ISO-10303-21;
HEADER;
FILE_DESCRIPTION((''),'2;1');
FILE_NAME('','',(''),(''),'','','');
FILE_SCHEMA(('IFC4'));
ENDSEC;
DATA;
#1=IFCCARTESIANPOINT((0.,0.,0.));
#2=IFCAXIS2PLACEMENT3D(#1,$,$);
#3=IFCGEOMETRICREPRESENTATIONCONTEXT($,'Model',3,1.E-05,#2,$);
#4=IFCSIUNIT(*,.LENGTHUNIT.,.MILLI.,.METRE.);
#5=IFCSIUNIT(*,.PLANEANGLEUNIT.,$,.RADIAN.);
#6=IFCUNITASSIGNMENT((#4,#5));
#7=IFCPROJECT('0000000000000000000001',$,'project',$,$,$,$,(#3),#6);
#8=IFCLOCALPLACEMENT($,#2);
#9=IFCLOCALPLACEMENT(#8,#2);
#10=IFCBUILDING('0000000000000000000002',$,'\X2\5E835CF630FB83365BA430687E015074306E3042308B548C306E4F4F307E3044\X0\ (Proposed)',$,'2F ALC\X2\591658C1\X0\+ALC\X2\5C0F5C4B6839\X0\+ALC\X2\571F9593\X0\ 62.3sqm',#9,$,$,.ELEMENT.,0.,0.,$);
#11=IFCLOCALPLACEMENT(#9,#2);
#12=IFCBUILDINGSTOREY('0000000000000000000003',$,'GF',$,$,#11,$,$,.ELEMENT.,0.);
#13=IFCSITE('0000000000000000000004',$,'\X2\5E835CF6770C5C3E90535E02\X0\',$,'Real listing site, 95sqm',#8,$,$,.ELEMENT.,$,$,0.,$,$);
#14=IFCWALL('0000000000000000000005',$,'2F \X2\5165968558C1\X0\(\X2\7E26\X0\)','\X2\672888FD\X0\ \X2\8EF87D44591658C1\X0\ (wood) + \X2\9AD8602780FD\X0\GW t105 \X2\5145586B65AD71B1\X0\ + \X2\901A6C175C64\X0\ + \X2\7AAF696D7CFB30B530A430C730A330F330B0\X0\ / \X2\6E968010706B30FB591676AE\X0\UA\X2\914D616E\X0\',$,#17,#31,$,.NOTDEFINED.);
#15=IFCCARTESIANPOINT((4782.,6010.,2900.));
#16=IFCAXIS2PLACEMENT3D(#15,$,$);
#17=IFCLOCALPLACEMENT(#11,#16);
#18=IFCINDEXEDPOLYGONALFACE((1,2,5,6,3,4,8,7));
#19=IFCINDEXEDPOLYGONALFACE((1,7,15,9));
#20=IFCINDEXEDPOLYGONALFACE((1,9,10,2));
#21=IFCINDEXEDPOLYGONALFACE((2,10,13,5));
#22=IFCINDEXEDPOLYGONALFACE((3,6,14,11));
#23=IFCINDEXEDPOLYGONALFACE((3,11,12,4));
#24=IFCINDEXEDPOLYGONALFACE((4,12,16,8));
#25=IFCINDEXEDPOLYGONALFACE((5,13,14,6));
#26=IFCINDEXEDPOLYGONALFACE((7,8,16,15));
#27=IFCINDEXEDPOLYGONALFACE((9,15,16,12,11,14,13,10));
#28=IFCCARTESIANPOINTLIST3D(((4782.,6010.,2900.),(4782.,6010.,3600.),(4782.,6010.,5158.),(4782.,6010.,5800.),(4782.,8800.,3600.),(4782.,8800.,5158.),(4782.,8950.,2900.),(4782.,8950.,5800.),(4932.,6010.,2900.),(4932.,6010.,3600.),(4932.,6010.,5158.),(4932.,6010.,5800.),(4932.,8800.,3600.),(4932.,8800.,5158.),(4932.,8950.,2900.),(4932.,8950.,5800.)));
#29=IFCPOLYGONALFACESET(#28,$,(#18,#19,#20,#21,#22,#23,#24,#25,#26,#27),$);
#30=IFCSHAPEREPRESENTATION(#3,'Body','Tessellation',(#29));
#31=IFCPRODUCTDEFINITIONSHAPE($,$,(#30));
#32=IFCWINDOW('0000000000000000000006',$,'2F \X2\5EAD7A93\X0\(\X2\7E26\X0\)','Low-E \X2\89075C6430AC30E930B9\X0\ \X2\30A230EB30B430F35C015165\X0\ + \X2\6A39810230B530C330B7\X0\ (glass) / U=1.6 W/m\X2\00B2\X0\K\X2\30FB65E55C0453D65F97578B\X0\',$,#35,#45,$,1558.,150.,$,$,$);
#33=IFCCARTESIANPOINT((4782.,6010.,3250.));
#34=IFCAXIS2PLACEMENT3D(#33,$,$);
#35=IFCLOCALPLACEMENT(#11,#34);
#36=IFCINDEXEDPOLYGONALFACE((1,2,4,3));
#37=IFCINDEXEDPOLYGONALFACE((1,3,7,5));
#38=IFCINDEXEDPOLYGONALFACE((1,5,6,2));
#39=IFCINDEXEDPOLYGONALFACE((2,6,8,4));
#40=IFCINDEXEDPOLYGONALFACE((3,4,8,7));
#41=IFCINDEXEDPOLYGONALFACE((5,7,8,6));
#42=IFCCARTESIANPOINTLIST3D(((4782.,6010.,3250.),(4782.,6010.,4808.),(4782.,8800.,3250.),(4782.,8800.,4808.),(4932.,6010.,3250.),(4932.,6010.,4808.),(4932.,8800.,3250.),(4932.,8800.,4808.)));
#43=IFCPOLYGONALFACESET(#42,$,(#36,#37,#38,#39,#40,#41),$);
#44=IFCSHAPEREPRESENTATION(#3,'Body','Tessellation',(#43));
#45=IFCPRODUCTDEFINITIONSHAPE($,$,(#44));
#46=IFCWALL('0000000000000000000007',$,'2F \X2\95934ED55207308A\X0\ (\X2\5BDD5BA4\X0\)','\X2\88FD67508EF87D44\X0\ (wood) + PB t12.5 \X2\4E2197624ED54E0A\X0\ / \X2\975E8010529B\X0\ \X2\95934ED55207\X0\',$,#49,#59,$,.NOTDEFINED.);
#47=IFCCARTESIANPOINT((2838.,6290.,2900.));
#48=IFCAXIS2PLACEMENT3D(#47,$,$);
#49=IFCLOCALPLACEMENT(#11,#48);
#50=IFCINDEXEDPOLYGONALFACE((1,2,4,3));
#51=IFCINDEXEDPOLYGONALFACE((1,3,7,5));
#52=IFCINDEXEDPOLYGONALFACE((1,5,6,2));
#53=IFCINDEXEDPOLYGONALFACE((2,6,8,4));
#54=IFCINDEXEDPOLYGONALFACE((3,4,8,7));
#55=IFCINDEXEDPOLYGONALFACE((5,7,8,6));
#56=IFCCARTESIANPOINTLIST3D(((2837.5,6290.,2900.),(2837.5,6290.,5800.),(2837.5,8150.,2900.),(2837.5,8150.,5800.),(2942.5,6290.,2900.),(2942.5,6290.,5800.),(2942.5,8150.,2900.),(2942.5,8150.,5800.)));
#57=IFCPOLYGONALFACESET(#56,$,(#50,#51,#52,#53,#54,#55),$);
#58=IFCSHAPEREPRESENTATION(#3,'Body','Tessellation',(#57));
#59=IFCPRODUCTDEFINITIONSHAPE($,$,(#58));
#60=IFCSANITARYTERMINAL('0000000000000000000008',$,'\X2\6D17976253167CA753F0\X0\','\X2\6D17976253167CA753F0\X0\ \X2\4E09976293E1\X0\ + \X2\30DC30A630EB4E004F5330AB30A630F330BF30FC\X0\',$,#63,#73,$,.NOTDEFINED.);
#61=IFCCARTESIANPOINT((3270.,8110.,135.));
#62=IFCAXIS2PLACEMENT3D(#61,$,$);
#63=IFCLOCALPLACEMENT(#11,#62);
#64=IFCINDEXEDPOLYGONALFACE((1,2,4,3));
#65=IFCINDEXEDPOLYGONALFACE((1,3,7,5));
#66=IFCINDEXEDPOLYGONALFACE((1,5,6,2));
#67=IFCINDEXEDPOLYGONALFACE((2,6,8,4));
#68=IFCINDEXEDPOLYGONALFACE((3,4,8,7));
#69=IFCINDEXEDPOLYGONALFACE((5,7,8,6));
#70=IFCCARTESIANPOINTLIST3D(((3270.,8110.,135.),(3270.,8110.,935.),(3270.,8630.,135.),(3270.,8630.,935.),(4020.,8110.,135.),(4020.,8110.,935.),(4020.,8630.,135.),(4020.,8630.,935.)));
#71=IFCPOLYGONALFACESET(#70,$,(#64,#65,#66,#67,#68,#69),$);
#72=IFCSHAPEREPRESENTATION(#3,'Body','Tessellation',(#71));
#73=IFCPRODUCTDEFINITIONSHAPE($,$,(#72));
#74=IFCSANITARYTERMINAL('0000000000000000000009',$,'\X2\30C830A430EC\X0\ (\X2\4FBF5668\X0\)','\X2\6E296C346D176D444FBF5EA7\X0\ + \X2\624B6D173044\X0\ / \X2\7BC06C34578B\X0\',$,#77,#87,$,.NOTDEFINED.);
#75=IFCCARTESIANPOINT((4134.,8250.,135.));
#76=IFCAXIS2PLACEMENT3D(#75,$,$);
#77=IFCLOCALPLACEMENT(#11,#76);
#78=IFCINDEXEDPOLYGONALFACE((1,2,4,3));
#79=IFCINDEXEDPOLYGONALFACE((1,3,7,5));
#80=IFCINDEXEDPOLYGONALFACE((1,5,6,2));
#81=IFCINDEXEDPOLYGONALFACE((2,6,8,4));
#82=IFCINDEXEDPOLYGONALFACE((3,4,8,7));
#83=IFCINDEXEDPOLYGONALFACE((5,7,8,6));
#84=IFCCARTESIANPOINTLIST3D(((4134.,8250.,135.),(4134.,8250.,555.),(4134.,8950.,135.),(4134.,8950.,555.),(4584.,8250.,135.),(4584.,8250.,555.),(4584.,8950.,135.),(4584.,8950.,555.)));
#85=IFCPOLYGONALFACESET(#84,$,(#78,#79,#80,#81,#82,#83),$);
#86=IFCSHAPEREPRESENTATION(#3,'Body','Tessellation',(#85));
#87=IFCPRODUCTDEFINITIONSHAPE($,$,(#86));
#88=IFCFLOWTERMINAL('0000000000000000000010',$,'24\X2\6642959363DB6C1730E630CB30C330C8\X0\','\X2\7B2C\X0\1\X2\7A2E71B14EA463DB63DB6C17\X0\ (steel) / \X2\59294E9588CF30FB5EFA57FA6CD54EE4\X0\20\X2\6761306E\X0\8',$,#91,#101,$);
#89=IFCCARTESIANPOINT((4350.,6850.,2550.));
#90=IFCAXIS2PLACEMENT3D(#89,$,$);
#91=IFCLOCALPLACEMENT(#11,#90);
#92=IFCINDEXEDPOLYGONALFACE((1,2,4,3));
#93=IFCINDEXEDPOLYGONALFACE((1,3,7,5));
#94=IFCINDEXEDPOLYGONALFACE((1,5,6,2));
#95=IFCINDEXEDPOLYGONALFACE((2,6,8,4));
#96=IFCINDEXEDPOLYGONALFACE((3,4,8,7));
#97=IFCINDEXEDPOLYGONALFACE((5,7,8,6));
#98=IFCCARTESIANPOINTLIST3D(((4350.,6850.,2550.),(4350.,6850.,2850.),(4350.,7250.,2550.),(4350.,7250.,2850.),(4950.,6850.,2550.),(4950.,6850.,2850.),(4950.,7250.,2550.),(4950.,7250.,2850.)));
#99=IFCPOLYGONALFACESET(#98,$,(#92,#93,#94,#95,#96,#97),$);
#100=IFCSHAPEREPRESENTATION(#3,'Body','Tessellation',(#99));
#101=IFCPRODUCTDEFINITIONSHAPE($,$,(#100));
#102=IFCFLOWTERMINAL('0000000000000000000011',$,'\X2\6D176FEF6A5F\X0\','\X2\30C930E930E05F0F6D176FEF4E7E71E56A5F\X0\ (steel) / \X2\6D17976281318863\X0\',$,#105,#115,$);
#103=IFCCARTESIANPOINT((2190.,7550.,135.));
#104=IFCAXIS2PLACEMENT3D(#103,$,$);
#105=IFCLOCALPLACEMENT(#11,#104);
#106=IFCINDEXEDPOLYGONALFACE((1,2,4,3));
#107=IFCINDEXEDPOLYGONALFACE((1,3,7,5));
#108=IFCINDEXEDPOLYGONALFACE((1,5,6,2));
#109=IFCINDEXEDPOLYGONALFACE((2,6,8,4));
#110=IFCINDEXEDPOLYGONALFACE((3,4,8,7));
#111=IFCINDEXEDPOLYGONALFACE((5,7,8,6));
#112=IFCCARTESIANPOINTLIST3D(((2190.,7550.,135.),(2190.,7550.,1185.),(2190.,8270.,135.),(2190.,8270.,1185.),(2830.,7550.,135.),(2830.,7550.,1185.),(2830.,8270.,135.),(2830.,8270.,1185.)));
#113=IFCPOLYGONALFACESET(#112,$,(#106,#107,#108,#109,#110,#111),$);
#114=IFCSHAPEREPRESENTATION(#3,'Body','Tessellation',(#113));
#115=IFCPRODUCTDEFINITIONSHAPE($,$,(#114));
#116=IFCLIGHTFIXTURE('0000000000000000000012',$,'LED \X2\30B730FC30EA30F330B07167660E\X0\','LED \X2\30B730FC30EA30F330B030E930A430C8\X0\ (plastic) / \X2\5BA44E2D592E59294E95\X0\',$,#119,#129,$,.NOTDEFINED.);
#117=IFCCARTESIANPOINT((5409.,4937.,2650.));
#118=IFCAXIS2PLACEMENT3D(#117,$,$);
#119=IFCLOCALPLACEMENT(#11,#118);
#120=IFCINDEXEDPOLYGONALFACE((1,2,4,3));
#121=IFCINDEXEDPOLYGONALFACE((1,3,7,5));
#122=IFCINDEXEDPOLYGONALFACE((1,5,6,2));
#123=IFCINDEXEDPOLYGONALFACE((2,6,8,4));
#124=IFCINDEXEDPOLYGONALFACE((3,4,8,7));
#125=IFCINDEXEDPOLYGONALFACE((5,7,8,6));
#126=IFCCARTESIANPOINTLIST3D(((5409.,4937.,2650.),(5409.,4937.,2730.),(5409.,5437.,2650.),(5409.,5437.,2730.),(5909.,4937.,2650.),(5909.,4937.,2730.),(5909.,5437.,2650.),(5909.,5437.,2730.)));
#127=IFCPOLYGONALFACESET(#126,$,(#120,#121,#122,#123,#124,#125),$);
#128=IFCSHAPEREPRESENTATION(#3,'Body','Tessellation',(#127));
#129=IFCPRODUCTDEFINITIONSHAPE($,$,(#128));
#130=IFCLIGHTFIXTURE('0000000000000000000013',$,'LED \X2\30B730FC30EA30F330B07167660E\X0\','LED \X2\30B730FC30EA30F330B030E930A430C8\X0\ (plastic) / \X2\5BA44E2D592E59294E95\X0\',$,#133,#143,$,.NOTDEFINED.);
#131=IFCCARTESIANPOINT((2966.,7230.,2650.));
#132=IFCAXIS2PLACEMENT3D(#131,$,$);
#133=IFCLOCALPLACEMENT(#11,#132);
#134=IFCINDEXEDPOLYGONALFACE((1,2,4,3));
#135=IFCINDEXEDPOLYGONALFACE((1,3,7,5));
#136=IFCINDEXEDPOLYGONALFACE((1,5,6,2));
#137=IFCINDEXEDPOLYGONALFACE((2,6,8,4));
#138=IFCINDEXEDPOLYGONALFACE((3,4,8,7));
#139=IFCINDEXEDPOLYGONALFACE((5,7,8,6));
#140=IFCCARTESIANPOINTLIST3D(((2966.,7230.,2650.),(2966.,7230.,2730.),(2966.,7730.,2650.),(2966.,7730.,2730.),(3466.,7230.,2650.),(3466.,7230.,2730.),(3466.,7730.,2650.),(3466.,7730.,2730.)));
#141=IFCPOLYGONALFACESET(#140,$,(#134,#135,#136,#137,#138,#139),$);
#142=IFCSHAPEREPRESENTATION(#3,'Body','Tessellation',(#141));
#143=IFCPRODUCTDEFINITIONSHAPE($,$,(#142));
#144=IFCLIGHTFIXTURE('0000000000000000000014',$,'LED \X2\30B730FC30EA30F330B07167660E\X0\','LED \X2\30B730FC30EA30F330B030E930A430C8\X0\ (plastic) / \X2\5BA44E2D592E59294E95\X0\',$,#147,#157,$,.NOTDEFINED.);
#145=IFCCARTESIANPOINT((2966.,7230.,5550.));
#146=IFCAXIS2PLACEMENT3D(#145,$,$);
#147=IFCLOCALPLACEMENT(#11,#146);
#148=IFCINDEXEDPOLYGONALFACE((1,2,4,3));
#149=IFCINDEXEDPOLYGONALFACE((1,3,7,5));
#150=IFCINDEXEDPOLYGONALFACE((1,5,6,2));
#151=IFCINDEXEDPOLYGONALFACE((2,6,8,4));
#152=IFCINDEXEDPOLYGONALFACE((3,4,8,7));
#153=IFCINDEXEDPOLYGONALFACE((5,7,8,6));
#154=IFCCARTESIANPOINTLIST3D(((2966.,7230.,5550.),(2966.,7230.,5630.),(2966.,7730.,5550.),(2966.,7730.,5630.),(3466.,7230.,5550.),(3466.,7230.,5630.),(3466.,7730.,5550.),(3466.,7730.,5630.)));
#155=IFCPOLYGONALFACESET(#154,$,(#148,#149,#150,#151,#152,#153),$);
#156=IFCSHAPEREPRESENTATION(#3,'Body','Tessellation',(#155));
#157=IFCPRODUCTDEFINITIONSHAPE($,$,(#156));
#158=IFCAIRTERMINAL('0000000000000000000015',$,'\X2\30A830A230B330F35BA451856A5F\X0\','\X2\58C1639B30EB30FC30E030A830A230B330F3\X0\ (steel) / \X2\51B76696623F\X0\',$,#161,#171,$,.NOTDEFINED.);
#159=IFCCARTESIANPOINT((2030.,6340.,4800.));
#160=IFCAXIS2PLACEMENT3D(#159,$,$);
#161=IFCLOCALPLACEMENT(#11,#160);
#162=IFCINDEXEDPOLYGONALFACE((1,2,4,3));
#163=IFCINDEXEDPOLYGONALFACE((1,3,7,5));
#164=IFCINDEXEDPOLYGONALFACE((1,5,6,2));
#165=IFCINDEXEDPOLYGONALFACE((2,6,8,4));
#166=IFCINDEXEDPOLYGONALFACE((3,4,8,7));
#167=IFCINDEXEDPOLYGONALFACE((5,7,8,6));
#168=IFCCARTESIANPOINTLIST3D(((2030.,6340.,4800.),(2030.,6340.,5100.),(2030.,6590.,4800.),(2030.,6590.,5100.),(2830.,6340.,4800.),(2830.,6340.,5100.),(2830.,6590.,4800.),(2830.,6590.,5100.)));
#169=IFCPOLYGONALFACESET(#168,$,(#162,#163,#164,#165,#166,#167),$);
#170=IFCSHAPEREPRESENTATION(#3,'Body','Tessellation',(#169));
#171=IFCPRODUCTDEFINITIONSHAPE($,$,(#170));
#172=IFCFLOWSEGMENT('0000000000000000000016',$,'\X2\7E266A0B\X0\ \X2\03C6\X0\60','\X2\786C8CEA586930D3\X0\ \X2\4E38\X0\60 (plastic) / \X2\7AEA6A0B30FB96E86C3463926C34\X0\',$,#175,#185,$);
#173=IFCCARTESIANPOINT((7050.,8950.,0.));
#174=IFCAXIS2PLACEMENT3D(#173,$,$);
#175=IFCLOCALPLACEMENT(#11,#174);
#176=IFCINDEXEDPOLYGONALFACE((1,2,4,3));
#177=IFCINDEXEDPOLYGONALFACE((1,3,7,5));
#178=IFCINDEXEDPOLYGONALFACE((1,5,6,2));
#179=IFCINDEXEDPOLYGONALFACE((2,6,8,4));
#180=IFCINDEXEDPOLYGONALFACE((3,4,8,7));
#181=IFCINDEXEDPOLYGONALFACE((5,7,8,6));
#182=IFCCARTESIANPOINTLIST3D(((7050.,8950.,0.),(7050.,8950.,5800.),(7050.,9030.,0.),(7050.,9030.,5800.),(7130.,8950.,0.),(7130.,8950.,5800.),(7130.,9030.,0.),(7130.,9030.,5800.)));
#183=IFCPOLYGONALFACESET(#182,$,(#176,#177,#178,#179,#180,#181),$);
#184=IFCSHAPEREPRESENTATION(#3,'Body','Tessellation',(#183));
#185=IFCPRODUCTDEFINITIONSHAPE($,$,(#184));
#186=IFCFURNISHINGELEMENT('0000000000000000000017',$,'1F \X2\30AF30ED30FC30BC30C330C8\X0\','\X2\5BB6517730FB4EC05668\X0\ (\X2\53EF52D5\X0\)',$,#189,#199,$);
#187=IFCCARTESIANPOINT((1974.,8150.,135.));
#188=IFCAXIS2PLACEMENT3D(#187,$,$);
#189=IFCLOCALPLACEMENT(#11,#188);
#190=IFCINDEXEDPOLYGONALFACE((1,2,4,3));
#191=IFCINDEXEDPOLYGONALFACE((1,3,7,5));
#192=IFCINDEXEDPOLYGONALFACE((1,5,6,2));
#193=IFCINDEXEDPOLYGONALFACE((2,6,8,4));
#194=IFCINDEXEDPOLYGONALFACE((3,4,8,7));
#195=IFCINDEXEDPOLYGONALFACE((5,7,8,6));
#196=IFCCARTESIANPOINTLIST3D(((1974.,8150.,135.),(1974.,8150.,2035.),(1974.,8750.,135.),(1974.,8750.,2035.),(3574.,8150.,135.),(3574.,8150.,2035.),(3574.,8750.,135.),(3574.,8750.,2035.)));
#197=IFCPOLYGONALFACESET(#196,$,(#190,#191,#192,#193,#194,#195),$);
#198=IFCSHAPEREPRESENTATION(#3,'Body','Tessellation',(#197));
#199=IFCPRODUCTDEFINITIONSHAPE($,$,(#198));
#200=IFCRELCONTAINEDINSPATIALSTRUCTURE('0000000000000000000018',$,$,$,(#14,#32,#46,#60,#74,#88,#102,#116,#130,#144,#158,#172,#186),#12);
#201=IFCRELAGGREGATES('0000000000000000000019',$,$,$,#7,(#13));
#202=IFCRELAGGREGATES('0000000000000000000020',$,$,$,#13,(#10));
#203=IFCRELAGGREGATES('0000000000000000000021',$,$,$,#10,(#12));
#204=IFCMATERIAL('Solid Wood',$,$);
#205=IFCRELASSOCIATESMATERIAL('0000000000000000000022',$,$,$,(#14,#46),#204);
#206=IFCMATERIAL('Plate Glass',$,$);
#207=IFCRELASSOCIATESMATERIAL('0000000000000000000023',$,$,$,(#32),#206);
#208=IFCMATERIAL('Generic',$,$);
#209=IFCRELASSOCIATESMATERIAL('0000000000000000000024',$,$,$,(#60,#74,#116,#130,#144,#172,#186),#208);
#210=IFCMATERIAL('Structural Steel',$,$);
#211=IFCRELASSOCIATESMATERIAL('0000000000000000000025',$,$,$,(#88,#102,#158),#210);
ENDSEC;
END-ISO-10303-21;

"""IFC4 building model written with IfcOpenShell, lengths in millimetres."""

from ifc_helpers import new_model, si_unit, frame, frame_2d, origin, place, context, project, spatial, rectangle, extrude, material, element, fill, save


model = new_model("IFC4")

# Units and contexts
model_context = context("Model", 3, precision=1e-05, world=origin())
ifc_project = project(units=[si_unit("LENGTHUNIT", "METRE", prefix="MILLI"), si_unit("PLANEANGLEUNIT", "RADIAN")], contexts=[model_context])

# Site, building, storey
site_placement = place(None, origin())
site = spatial("IfcSite", under=ifc_project, at=site_placement, Name="広島県尾道市", ObjectType="Real listing site, 95sqm", CompositionType="ELEMENT", RefElevation=0.0)
building_placement = place(site_placement, origin())
building = spatial("IfcBuilding", under=site, at=building_placement, Name="広島・茶室と縁側のある和の住まい (Proposed)", ObjectType="2F ALC外壁+ALC小屋根+ALC土間 62.3sqm", CompositionType="ELEMENT", ElevationOfRefHeight=0.0, ElevationOfTerrain=0.0)
storey_placement = place(building_placement, origin())
storey = spatial("IfcBuildingStorey", under=building, at=storey_placement, Name="GF", CompositionType="ELEMENT", Elevation=0.0)

# Shared definitions
ifc_material_1 = material(Name="Solid Wood")

# Shared definitions
ifc_material_2 = material(Name="Plate Glass")

# Wall, opening, window
wall_1_placement = place(storey_placement, frame((4782.0, 6010.0, 2900.0)))
wall_1 = element("IfcWall", 1, at=wall_1_placement, inside=storey, material=ifc_material_1, Name="2F 入隅壁(縦)", Description="木製 軸組外壁 (wood) + 高性能GW t105 充填断熱 + 通気層 + 窯業系サイディング / 準耐火・外皮UA配慮", PredefinedType="NOTDEFINED", context=model_context, shape_type="SweptSolid", body=[
    extrude(rectangle(XDim=150.0, YDim=2940.0, at=frame_2d((75.0, 1470.0))), frame((4782.0, 6010.0, 2900.0)), (0.0, 0.0, 1.0), 2900.0),
])
opening_1_placement = place(storey_placement, frame((4782.0, 6010.0, 3250.0)))
opening_1 = element("IfcOpeningElement", 2, at=opening_1_placement, cuts=wall_1, PredefinedType="NOTDEFINED", context=model_context, shape_type="SweptSolid", body=[
    extrude(rectangle(XDim=150.0, YDim=2790.0, at=frame_2d((75.0, 1395.0))), frame((4782.0, 6010.0, 3250.0)), (0.0, 0.0, 1.0), 1558.0),
])
window_1_placement = place(storey_placement, frame((4782.0, 6010.0, 3250.0)))
window_1 = element("IfcWindow", 3, at=window_1_placement, inside=storey, material=ifc_material_2, Name="2F 庭窓(縦)", Description="Low-E 複層ガラス アルゴン封入 + 樹脂サッシ (glass) / U=1.6 W/m²K・日射取得型", OverallHeight=1558.0, OverallWidth=150.0, context=model_context, shape_type="SweptSolid", body=[
    extrude(rectangle(XDim=150.0, YDim=2790.0, at=frame_2d((75.0, 1395.0))), frame((4782.0, 6010.0, 3250.0)), (0.0, 0.0, 1.0), 1558.0),
])
fill(opening_1, window_1)

# Wall
wall_2_placement = place(storey_placement, frame((2838.0, 6290.0, 2900.0)))
element("IfcWall", 4, at=wall_2_placement, inside=storey, material=ifc_material_1, Name="2F 間仕切り (寝室)", Description="製材軸組 (wood) + PB t12.5 両面仕上 / 非耐力 間仕切", PredefinedType="NOTDEFINED", context=model_context, shape_type="SweptSolid", body=[
    extrude(rectangle(XDim=105.0, YDim=1860.0, at=frame_2d((52.0, 930.0))), frame((2838.0, 6290.0, 2900.0)), (0.0, 0.0, 1.0), 2900.0),
])

# Sanitary terminals
ifc_material_3 = material(Name="Generic")
sanitary_terminal_1_placement = place(storey_placement, frame((3270.0, 8110.0, 135.0)))
element("IfcSanitaryTerminal", 5, at=sanitary_terminal_1_placement, inside=storey, material=ifc_material_3, Name="洗面化粧台", Description="洗面化粧台 三面鏡 + ボウル一体カウンター", PredefinedType="NOTDEFINED", context=model_context, shape_type="SweptSolid", body=[
    extrude(rectangle(XDim=750.0, YDim=520.0, at=frame_2d((375.0, 260.0))), frame((3270.0, 8110.0, 135.0)), (0.0, 0.0, 1.0), 800.0),
])
sanitary_terminal_2_placement = place(storey_placement, frame((4134.0, 8250.0, 135.0)))
element("IfcSanitaryTerminal", 6, at=sanitary_terminal_2_placement, inside=storey, material=ifc_material_3, Name="トイレ (便器)", Description="温水洗浄便座 + 手洗い / 節水型", PredefinedType="NOTDEFINED", context=model_context, shape_type="SweptSolid", body=[
    extrude(rectangle(XDim=450.0, YDim=700.0, at=frame_2d((225.0, 350.0))), frame((4134.0, 8250.0, 135.0)), (0.0, 0.0, 1.0), 420.0),
])

# Flow terminals
ifc_material_4 = material(Name="Structural Steel")
flow_terminal_1_placement = place(storey_placement, frame((4350.0, 6850.0, 2550.0)))
element("IfcFlowTerminal", 7, at=flow_terminal_1_placement, inside=storey, material=ifc_material_4, Name="24時間換気ユニット", Description="第1種熱交換換気 (steel) / 天井裏・建基法令20条の8", context=model_context, shape_type="SweptSolid", body=[
    extrude(rectangle(XDim=600.0, YDim=400.0, at=frame_2d((300.0, 200.0))), frame((4350.0, 6850.0, 2550.0)), (0.0, 0.0, 1.0), 300.0),
])
flow_terminal_2_placement = place(storey_placement, frame((2190.0, 7550.0, 135.0)))
element("IfcFlowTerminal", 8, at=flow_terminal_2_placement, inside=storey, material=ifc_material_4, Name="洗濯機", Description="ドラム式洗濯乾燥機 (steel) / 洗面脱衣", context=model_context, shape_type="SweptSolid", body=[
    extrude(rectangle(XDim=640.0, YDim=720.0, at=frame_2d((320.0, 360.0))), frame((2190.0, 7550.0, 135.0)), (0.0, 0.0, 1.0), 1050.0),
])

# Light fixtures
light_fixture_1_placement = place(storey_placement, frame((5409.0, 4937.0, 2650.0)))
element("IfcLightFixture", 9, at=light_fixture_1_placement, inside=storey, material=ifc_material_3, Name="LED シーリング照明", Description="LED シーリングライト (plastic) / 室中央天井", PredefinedType="NOTDEFINED", context=model_context, shape_type="SweptSolid", body=[
    extrude(rectangle(XDim=500.0, YDim=500.0, at=frame_2d((250.0, 250.0))), frame((5409.0, 4937.0, 2650.0)), (0.0, 0.0, 1.0), 80.0),
])
light_fixture_2_placement = place(storey_placement, frame((2966.0, 7230.0, 2650.0)))
element("IfcLightFixture", 10, at=light_fixture_2_placement, inside=storey, material=ifc_material_3, Name="LED シーリング照明", Description="LED シーリングライト (plastic) / 室中央天井", PredefinedType="NOTDEFINED", context=model_context, shape_type="SweptSolid", body=[
    extrude(rectangle(XDim=500.0, YDim=500.0, at=frame_2d((250.0, 250.0))), frame((2966.0, 7230.0, 2650.0)), (0.0, 0.0, 1.0), 80.0),
])
light_fixture_3_placement = place(storey_placement, frame((2966.0, 7230.0, 5550.0)))
element("IfcLightFixture", 11, at=light_fixture_3_placement, inside=storey, material=ifc_material_3, Name="LED シーリング照明", Description="LED シーリングライト (plastic) / 室中央天井", PredefinedType="NOTDEFINED", context=model_context, shape_type="SweptSolid", body=[
    extrude(rectangle(XDim=500.0, YDim=500.0, at=frame_2d((250.0, 250.0))), frame((2966.0, 7230.0, 5550.0)), (0.0, 0.0, 1.0), 80.0),
])

# Air terminal
air_terminal_placement = place(storey_placement, frame((2030.0, 6340.0, 4800.0)))
element("IfcAirTerminal", 12, at=air_terminal_placement, inside=storey, material=ifc_material_4, Name="エアコン室内機", Description="壁掛ルームエアコン (steel) / 冷暖房", PredefinedType="NOTDEFINED", context=model_context, shape_type="SweptSolid", body=[
    extrude(rectangle(XDim=800.0, YDim=250.0, at=frame_2d((400.0, 125.0))), frame((2030.0, 6340.0, 4800.0)), (0.0, 0.0, 1.0), 300.0),
])

# Flow segment
flow_segment_placement = place(storey_placement, frame((7050.0, 8950.0, 0.0)))
element("IfcFlowSegment", 13, at=flow_segment_placement, inside=storey, material=ifc_material_3, Name="縦樋 φ60", Description="硬質塩ビ 丸60 (plastic) / 竪樋・雨水排水", context=model_context, shape_type="SweptSolid", body=[
    extrude(rectangle(XDim=80.0, YDim=80.0, at=frame_2d((40.0, 40.0))), frame((7050.0, 8950.0, 0.0)), (0.0, 0.0, 1.0), 5800.0),
])

# Furnishing element
furnishing_1_placement = place(storey_placement, frame((1974.0, 8150.0, 135.0)))
element("IfcFurnishingElement", 14, at=furnishing_1_placement, inside=storey, material=ifc_material_3, Name="1F クローゼット", Description="家具・什器 (可動)", context=model_context, shape_type="SweptSolid", body=[
    extrude(rectangle(XDim=1600.0, YDim=600.0, at=frame_2d((800.0, 300.0))), frame((1974.0, 8150.0, 135.0)), (0.0, 0.0, 1.0), 1900.0),
])

save(model, "model.ifc")
